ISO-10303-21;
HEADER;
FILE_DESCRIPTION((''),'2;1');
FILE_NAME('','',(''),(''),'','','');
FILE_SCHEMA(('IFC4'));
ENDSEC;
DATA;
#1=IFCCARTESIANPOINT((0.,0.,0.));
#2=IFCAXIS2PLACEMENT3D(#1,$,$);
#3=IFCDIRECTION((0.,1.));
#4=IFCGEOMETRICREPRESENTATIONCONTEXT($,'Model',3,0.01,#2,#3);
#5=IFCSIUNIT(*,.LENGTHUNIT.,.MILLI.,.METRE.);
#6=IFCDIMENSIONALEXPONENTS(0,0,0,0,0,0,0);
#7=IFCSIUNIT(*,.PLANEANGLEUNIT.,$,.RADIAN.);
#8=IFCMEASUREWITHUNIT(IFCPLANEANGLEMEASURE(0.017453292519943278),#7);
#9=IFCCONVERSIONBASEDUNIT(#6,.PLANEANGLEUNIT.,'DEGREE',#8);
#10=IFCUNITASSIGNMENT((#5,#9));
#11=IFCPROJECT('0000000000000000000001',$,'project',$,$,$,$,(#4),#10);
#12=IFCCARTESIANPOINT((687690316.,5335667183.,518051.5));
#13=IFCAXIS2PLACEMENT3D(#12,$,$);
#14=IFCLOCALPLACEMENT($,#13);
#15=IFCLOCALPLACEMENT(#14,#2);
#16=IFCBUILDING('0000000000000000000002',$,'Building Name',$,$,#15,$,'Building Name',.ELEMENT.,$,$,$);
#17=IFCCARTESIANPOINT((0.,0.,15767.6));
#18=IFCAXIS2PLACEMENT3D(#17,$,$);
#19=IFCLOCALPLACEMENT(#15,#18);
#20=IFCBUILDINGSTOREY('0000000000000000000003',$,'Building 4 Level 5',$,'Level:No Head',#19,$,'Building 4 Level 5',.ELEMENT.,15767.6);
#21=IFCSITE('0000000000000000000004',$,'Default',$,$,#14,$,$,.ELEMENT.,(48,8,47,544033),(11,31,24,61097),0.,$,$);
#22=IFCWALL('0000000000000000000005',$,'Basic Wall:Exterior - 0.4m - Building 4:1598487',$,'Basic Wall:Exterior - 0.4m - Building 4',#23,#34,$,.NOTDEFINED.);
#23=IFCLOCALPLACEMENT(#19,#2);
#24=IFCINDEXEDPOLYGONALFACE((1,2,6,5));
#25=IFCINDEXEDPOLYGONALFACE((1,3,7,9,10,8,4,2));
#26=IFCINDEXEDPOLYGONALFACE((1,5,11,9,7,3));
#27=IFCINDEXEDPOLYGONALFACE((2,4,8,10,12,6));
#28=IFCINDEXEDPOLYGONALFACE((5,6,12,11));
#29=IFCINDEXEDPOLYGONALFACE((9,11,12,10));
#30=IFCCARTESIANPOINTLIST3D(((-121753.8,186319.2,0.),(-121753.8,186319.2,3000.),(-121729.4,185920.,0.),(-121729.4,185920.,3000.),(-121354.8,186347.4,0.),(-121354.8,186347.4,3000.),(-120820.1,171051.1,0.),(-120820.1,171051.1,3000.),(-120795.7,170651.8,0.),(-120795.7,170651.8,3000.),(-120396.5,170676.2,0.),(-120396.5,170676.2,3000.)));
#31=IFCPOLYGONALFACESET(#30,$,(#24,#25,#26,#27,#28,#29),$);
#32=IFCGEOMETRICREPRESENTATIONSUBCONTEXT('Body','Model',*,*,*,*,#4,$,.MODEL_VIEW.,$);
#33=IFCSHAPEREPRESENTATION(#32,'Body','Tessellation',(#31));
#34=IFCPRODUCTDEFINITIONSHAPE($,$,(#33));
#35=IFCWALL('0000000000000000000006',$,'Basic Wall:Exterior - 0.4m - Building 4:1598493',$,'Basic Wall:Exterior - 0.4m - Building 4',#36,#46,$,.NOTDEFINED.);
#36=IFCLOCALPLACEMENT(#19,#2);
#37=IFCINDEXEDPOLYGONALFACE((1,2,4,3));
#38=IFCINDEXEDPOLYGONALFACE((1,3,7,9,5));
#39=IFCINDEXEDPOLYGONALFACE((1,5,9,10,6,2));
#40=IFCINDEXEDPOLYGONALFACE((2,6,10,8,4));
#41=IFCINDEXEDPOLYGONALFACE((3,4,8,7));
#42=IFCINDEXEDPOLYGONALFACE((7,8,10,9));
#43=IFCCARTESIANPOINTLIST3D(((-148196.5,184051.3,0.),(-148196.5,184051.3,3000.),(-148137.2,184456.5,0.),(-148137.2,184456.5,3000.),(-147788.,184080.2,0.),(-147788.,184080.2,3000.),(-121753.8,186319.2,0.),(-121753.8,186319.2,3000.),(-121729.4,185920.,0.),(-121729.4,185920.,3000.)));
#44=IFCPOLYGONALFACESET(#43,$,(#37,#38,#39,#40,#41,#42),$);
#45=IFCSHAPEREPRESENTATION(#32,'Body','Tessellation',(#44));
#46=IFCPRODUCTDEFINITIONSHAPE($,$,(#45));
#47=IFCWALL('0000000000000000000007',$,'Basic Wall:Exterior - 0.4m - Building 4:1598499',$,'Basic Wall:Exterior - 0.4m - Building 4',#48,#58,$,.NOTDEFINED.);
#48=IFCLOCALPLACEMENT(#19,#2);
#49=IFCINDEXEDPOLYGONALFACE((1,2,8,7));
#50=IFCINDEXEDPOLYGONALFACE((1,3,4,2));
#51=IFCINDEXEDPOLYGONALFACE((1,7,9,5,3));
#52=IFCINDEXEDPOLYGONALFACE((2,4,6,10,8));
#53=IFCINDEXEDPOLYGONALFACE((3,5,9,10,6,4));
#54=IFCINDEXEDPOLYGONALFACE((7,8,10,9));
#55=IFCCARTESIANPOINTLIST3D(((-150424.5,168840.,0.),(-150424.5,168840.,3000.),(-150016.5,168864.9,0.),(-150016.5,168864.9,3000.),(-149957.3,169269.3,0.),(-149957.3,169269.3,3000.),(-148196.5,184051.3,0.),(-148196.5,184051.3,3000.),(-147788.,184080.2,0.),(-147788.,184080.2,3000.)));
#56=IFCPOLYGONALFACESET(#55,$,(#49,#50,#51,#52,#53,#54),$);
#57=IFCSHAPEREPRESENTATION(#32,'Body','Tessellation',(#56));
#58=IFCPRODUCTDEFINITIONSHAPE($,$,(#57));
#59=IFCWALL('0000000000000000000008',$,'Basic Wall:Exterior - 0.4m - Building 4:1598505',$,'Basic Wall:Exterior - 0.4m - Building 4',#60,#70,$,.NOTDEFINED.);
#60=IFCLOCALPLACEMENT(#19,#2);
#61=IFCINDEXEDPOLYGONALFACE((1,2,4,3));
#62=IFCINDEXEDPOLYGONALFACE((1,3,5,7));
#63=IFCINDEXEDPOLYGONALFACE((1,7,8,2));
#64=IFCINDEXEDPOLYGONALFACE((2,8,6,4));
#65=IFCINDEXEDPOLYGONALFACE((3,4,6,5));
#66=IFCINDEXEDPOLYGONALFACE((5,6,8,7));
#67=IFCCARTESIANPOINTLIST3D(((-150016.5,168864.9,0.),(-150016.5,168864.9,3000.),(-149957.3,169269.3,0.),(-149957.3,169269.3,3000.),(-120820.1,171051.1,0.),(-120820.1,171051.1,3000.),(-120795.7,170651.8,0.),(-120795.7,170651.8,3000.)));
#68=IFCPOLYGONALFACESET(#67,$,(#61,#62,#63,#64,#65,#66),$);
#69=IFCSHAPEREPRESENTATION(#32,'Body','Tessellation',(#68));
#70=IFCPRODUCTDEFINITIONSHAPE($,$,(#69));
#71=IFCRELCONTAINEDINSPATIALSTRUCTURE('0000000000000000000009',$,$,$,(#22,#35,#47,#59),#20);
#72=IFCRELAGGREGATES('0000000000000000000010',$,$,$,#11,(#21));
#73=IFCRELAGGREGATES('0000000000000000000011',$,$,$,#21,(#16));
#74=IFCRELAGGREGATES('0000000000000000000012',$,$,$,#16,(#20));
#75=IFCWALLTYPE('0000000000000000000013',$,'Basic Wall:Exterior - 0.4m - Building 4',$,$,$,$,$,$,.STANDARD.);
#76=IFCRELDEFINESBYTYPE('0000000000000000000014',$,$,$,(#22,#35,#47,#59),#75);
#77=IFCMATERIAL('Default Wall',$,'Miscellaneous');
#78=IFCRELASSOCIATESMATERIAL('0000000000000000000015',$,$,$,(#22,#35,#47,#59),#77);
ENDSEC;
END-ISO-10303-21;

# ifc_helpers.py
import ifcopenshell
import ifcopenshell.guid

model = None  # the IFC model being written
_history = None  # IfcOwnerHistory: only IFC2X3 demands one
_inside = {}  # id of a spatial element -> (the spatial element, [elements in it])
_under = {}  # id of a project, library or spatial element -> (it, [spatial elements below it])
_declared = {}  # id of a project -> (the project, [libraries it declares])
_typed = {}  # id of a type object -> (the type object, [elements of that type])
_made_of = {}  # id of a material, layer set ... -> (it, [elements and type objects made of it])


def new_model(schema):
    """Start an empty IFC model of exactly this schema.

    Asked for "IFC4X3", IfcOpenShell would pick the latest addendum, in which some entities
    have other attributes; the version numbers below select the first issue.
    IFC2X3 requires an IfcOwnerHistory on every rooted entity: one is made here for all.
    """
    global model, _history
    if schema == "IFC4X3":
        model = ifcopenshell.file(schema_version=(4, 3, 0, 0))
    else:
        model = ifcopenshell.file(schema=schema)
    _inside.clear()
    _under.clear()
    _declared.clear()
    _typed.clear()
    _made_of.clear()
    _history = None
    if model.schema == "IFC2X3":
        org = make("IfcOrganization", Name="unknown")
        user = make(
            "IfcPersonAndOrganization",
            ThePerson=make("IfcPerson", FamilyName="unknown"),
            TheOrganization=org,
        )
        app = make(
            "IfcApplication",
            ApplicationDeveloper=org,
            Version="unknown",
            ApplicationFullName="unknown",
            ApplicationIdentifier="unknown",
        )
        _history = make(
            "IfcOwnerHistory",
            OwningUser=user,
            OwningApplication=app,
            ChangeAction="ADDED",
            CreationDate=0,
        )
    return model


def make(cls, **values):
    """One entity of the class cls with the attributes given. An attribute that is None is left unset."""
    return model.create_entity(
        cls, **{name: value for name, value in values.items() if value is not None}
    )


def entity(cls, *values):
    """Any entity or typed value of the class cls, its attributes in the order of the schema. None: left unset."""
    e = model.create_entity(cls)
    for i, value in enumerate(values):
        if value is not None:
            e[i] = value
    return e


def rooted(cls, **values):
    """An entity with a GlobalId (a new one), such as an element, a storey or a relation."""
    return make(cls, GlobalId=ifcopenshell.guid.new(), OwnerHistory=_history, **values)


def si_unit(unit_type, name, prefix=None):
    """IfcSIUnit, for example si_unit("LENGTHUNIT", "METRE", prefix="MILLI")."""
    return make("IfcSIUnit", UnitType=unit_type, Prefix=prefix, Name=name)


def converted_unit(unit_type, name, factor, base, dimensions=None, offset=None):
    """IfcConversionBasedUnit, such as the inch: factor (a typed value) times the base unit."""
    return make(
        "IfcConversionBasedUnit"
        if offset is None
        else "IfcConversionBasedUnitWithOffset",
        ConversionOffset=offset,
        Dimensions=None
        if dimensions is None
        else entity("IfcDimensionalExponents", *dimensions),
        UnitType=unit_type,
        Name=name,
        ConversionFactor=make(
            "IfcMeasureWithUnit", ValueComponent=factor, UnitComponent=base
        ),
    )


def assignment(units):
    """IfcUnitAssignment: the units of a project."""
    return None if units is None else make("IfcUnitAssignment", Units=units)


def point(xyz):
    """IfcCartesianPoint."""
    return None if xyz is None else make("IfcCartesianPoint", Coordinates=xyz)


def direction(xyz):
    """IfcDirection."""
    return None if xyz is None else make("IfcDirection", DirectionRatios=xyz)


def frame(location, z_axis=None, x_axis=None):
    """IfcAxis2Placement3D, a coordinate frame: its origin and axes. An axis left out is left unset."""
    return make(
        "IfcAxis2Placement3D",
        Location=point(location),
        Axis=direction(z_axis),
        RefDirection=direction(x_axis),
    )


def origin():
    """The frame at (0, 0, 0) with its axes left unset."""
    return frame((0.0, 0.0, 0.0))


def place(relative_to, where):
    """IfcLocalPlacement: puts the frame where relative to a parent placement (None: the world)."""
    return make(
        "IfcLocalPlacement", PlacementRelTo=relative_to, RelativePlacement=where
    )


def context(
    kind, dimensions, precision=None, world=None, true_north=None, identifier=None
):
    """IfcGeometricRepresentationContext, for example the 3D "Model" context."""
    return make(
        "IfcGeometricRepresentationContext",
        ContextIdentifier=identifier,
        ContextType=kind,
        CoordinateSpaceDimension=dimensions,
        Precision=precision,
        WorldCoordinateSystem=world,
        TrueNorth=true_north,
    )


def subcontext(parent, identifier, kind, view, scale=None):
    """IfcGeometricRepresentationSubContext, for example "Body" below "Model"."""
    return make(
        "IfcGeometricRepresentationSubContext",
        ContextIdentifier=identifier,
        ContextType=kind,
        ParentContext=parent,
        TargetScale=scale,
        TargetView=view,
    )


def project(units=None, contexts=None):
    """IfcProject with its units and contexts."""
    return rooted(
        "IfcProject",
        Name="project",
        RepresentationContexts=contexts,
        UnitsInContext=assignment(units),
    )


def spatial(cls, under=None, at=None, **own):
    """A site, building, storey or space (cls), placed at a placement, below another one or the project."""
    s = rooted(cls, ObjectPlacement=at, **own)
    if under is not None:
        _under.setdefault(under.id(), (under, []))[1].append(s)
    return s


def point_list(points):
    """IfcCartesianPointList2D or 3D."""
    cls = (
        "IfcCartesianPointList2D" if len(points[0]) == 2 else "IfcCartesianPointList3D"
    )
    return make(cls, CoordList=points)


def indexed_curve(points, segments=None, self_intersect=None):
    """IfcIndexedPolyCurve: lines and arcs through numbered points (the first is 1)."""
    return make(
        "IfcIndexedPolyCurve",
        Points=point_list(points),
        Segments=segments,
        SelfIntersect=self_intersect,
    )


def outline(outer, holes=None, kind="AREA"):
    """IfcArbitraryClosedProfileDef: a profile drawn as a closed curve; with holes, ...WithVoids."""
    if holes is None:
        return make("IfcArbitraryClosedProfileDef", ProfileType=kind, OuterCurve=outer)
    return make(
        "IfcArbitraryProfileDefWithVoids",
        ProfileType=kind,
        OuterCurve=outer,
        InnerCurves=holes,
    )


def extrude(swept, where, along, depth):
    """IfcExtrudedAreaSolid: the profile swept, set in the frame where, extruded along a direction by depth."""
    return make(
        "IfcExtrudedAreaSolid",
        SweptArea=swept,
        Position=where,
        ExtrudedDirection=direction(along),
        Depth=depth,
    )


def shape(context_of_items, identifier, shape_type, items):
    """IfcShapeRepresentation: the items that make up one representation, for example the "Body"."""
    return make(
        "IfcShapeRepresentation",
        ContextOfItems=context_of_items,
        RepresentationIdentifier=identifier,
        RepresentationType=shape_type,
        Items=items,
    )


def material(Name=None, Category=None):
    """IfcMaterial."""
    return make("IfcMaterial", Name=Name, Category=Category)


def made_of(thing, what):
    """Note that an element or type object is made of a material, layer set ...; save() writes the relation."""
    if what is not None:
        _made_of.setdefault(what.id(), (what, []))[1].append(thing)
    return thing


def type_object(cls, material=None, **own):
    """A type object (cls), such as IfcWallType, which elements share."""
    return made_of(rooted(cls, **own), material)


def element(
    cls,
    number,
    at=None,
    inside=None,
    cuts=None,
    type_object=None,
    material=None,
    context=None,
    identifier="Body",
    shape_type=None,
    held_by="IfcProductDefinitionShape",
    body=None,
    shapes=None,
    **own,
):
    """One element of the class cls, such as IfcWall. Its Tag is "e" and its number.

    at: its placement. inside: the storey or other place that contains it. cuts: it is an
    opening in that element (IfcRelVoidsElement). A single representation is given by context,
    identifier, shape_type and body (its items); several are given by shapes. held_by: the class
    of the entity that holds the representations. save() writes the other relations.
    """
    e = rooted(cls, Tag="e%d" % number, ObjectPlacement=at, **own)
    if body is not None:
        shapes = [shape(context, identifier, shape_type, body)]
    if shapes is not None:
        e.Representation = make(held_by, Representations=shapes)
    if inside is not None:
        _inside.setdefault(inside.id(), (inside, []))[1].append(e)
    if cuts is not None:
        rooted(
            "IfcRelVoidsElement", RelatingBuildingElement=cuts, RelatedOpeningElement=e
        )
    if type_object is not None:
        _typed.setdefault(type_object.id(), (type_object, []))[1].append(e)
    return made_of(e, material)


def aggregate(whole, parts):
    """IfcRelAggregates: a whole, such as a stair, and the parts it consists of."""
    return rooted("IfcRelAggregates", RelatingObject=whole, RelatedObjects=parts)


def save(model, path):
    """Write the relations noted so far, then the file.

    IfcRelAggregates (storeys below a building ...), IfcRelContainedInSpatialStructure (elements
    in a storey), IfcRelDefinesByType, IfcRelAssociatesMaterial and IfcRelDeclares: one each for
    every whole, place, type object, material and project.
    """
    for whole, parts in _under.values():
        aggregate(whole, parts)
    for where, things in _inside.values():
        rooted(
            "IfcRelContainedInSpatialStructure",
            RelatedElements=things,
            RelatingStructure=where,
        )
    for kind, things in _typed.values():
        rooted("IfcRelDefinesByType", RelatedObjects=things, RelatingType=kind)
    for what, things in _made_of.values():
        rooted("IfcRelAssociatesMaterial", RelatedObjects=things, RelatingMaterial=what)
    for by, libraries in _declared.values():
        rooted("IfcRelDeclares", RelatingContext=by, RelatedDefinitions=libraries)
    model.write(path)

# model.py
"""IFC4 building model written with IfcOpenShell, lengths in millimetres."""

from ifc_helpers import new_model, entity, si_unit, converted_unit, direction, frame, origin, place, context, subcontext, project, spatial, indexed_curve, outline, extrude, material, type_object, element, save


model = new_model("IFC4")

# Units and contexts
model_context = context("Model", 3, precision=0.01, world=origin(), true_north=direction((0.0, 1.0)))
body_context = subcontext(model_context, "Body", "Model", "MODEL_VIEW")
ifc_project = project(units=[si_unit("LENGTHUNIT", "METRE", prefix="MILLI"), converted_unit("PLANEANGLEUNIT", "DEGREE", entity("IfcPlaneAngleMeasure", 0.017453292519943278), si_unit("PLANEANGLEUNIT", "RADIAN"), dimensions=[0, 0, 0, 0, 0, 0, 0])], contexts=[model_context])

# Site, building, storey
site_placement = place(None, frame((687690316.0, 5335667183.0, 518051.5)))
site = spatial("IfcSite", under=ifc_project, at=site_placement, Name="Default", CompositionType="ELEMENT", RefLatitude=(48, 8, 47, 544033), RefLongitude=(11, 31, 24, 61097), RefElevation=0.0)
building_placement = place(site_placement, origin())
building = spatial("IfcBuilding", under=site, at=building_placement, Name="Building Name", LongName="Building Name", CompositionType="ELEMENT")
storey_placement = place(building_placement, frame((0.0, 0.0, 15767.6)))
storey = spatial("IfcBuildingStorey", under=building, at=storey_placement, Name="Building 4 Level 5", ObjectType="Level:No Head", LongName="Building 4 Level 5", CompositionType="ELEMENT", Elevation=15767.6)

# Walls
ifc_material_1 = material(Name="Default Wall", Category="Miscellaneous")
wall_type = type_object("IfcWallType", Name="Basic Wall:Exterior - 0.4m - Building 4", PredefinedType="STANDARD")
wall_1_placement = place(storey_placement, frame((-120596.1, 170664.0, 0.0), z_axis=(0.0, 0.0, 1.0), x_axis=(-0.061037, 0.998136, 0.0)))
element("IfcWall", 1, at=wall_1_placement, inside=storey, type_object=wall_type, material=ifc_material_1, Name="Basic Wall:Exterior - 0.4m - Building 4:1598487", ObjectType="Basic Wall:Exterior - 0.4m - Building 4", PredefinedType="NOTDEFINED", context=body_context, shape_type="SweptSolid", body=[
    extrude(outline(indexed_curve([(15700.4, -200.0), (15696.7, 200.0), (15296.7, 200.0), (400.0, 200.0), (0.0, 200.0), (0.0, -200.0), (15700.4, -200.0)], self_intersect=False)), origin(), (0.0, 0.0, 1.0), 3000.0),
])
wall_2_placement = place(storey_placement, frame((-121739.7, 186119.7, 0.0), z_axis=(0.0, 0.0, 1.0), x_axis=(-0.997517, -0.070427, 0.0)))
element("IfcWall", 2, at=wall_2_placement, inside=storey, type_object=wall_type, material=ifc_material_1, Name="Basic Wall:Exterior - 0.4m - Building 4:1598493", ObjectType="Basic Wall:Exterior - 0.4m - Building 4", PredefinedType="NOTDEFINED", context=body_context, shape_type="SweptSolid", body=[
    extrude(outline(indexed_curve([(26449.1, -200.0), (26536.8, 200.0), (26127.3, 200.0), (3.8, 200.0), (0.0, -200.0), (26449.1, -200.0)], self_intersect=False)), origin(), (0.0, 0.0, 1.0), 3000.0),
])
wall_3_placement = place(storey_placement, frame((-147985.9, 184109.1, 0.0), z_axis=(0.0, 0.0, 1.0), x_axis=(-0.144921, -0.989443, 0.0)))
element("IfcWall", 3, at=wall_3_placement, inside=storey, type_object=wall_type, material=ifc_material_1, Name="Basic Wall:Exterior - 0.4m - Building 4:1598499", ObjectType="Basic Wall:Exterior - 0.4m - Building 4", PredefinedType="NOTDEFINED", context=body_context, shape_type="SweptSolid", body=[
    extrude(outline(indexed_curve([(15461.4, -200.0), (15377.6, 200.0), (14968.9, 200.0), (0.0, 200.0), (87.7, -200.0), (15461.4, -200.0)], self_intersect=False)), origin(), (0.0, 0.0, 1.0), 3000.0),
])
wall_4_placement = place(storey_placement, frame((-150028.8, 169064.6, 0.0), z_axis=(0.0, 0.0, 1.0), x_axis=(0.998136, 0.061037, 0.0)))
element("IfcWall", 4, at=wall_4_placement, inside=storey, type_object=wall_type, material=ifc_material_1, Name="Basic Wall:Exterior - 0.4m - Building 4:1598505", ObjectType="Basic Wall:Exterior - 0.4m - Building 4", PredefinedType="NOTDEFINED", context=body_context, shape_type="SweptSolid", body=[
    extrude(outline(indexed_curve([(29275.4, -200.0), (29275.4, 200.0), (83.8, 200.0), (0.0, -200.0), (29275.4, -200.0)], self_intersect=False)), origin(), (0.0, 0.0, 1.0), 3000.0),
])

save(model, "model.ifc")
